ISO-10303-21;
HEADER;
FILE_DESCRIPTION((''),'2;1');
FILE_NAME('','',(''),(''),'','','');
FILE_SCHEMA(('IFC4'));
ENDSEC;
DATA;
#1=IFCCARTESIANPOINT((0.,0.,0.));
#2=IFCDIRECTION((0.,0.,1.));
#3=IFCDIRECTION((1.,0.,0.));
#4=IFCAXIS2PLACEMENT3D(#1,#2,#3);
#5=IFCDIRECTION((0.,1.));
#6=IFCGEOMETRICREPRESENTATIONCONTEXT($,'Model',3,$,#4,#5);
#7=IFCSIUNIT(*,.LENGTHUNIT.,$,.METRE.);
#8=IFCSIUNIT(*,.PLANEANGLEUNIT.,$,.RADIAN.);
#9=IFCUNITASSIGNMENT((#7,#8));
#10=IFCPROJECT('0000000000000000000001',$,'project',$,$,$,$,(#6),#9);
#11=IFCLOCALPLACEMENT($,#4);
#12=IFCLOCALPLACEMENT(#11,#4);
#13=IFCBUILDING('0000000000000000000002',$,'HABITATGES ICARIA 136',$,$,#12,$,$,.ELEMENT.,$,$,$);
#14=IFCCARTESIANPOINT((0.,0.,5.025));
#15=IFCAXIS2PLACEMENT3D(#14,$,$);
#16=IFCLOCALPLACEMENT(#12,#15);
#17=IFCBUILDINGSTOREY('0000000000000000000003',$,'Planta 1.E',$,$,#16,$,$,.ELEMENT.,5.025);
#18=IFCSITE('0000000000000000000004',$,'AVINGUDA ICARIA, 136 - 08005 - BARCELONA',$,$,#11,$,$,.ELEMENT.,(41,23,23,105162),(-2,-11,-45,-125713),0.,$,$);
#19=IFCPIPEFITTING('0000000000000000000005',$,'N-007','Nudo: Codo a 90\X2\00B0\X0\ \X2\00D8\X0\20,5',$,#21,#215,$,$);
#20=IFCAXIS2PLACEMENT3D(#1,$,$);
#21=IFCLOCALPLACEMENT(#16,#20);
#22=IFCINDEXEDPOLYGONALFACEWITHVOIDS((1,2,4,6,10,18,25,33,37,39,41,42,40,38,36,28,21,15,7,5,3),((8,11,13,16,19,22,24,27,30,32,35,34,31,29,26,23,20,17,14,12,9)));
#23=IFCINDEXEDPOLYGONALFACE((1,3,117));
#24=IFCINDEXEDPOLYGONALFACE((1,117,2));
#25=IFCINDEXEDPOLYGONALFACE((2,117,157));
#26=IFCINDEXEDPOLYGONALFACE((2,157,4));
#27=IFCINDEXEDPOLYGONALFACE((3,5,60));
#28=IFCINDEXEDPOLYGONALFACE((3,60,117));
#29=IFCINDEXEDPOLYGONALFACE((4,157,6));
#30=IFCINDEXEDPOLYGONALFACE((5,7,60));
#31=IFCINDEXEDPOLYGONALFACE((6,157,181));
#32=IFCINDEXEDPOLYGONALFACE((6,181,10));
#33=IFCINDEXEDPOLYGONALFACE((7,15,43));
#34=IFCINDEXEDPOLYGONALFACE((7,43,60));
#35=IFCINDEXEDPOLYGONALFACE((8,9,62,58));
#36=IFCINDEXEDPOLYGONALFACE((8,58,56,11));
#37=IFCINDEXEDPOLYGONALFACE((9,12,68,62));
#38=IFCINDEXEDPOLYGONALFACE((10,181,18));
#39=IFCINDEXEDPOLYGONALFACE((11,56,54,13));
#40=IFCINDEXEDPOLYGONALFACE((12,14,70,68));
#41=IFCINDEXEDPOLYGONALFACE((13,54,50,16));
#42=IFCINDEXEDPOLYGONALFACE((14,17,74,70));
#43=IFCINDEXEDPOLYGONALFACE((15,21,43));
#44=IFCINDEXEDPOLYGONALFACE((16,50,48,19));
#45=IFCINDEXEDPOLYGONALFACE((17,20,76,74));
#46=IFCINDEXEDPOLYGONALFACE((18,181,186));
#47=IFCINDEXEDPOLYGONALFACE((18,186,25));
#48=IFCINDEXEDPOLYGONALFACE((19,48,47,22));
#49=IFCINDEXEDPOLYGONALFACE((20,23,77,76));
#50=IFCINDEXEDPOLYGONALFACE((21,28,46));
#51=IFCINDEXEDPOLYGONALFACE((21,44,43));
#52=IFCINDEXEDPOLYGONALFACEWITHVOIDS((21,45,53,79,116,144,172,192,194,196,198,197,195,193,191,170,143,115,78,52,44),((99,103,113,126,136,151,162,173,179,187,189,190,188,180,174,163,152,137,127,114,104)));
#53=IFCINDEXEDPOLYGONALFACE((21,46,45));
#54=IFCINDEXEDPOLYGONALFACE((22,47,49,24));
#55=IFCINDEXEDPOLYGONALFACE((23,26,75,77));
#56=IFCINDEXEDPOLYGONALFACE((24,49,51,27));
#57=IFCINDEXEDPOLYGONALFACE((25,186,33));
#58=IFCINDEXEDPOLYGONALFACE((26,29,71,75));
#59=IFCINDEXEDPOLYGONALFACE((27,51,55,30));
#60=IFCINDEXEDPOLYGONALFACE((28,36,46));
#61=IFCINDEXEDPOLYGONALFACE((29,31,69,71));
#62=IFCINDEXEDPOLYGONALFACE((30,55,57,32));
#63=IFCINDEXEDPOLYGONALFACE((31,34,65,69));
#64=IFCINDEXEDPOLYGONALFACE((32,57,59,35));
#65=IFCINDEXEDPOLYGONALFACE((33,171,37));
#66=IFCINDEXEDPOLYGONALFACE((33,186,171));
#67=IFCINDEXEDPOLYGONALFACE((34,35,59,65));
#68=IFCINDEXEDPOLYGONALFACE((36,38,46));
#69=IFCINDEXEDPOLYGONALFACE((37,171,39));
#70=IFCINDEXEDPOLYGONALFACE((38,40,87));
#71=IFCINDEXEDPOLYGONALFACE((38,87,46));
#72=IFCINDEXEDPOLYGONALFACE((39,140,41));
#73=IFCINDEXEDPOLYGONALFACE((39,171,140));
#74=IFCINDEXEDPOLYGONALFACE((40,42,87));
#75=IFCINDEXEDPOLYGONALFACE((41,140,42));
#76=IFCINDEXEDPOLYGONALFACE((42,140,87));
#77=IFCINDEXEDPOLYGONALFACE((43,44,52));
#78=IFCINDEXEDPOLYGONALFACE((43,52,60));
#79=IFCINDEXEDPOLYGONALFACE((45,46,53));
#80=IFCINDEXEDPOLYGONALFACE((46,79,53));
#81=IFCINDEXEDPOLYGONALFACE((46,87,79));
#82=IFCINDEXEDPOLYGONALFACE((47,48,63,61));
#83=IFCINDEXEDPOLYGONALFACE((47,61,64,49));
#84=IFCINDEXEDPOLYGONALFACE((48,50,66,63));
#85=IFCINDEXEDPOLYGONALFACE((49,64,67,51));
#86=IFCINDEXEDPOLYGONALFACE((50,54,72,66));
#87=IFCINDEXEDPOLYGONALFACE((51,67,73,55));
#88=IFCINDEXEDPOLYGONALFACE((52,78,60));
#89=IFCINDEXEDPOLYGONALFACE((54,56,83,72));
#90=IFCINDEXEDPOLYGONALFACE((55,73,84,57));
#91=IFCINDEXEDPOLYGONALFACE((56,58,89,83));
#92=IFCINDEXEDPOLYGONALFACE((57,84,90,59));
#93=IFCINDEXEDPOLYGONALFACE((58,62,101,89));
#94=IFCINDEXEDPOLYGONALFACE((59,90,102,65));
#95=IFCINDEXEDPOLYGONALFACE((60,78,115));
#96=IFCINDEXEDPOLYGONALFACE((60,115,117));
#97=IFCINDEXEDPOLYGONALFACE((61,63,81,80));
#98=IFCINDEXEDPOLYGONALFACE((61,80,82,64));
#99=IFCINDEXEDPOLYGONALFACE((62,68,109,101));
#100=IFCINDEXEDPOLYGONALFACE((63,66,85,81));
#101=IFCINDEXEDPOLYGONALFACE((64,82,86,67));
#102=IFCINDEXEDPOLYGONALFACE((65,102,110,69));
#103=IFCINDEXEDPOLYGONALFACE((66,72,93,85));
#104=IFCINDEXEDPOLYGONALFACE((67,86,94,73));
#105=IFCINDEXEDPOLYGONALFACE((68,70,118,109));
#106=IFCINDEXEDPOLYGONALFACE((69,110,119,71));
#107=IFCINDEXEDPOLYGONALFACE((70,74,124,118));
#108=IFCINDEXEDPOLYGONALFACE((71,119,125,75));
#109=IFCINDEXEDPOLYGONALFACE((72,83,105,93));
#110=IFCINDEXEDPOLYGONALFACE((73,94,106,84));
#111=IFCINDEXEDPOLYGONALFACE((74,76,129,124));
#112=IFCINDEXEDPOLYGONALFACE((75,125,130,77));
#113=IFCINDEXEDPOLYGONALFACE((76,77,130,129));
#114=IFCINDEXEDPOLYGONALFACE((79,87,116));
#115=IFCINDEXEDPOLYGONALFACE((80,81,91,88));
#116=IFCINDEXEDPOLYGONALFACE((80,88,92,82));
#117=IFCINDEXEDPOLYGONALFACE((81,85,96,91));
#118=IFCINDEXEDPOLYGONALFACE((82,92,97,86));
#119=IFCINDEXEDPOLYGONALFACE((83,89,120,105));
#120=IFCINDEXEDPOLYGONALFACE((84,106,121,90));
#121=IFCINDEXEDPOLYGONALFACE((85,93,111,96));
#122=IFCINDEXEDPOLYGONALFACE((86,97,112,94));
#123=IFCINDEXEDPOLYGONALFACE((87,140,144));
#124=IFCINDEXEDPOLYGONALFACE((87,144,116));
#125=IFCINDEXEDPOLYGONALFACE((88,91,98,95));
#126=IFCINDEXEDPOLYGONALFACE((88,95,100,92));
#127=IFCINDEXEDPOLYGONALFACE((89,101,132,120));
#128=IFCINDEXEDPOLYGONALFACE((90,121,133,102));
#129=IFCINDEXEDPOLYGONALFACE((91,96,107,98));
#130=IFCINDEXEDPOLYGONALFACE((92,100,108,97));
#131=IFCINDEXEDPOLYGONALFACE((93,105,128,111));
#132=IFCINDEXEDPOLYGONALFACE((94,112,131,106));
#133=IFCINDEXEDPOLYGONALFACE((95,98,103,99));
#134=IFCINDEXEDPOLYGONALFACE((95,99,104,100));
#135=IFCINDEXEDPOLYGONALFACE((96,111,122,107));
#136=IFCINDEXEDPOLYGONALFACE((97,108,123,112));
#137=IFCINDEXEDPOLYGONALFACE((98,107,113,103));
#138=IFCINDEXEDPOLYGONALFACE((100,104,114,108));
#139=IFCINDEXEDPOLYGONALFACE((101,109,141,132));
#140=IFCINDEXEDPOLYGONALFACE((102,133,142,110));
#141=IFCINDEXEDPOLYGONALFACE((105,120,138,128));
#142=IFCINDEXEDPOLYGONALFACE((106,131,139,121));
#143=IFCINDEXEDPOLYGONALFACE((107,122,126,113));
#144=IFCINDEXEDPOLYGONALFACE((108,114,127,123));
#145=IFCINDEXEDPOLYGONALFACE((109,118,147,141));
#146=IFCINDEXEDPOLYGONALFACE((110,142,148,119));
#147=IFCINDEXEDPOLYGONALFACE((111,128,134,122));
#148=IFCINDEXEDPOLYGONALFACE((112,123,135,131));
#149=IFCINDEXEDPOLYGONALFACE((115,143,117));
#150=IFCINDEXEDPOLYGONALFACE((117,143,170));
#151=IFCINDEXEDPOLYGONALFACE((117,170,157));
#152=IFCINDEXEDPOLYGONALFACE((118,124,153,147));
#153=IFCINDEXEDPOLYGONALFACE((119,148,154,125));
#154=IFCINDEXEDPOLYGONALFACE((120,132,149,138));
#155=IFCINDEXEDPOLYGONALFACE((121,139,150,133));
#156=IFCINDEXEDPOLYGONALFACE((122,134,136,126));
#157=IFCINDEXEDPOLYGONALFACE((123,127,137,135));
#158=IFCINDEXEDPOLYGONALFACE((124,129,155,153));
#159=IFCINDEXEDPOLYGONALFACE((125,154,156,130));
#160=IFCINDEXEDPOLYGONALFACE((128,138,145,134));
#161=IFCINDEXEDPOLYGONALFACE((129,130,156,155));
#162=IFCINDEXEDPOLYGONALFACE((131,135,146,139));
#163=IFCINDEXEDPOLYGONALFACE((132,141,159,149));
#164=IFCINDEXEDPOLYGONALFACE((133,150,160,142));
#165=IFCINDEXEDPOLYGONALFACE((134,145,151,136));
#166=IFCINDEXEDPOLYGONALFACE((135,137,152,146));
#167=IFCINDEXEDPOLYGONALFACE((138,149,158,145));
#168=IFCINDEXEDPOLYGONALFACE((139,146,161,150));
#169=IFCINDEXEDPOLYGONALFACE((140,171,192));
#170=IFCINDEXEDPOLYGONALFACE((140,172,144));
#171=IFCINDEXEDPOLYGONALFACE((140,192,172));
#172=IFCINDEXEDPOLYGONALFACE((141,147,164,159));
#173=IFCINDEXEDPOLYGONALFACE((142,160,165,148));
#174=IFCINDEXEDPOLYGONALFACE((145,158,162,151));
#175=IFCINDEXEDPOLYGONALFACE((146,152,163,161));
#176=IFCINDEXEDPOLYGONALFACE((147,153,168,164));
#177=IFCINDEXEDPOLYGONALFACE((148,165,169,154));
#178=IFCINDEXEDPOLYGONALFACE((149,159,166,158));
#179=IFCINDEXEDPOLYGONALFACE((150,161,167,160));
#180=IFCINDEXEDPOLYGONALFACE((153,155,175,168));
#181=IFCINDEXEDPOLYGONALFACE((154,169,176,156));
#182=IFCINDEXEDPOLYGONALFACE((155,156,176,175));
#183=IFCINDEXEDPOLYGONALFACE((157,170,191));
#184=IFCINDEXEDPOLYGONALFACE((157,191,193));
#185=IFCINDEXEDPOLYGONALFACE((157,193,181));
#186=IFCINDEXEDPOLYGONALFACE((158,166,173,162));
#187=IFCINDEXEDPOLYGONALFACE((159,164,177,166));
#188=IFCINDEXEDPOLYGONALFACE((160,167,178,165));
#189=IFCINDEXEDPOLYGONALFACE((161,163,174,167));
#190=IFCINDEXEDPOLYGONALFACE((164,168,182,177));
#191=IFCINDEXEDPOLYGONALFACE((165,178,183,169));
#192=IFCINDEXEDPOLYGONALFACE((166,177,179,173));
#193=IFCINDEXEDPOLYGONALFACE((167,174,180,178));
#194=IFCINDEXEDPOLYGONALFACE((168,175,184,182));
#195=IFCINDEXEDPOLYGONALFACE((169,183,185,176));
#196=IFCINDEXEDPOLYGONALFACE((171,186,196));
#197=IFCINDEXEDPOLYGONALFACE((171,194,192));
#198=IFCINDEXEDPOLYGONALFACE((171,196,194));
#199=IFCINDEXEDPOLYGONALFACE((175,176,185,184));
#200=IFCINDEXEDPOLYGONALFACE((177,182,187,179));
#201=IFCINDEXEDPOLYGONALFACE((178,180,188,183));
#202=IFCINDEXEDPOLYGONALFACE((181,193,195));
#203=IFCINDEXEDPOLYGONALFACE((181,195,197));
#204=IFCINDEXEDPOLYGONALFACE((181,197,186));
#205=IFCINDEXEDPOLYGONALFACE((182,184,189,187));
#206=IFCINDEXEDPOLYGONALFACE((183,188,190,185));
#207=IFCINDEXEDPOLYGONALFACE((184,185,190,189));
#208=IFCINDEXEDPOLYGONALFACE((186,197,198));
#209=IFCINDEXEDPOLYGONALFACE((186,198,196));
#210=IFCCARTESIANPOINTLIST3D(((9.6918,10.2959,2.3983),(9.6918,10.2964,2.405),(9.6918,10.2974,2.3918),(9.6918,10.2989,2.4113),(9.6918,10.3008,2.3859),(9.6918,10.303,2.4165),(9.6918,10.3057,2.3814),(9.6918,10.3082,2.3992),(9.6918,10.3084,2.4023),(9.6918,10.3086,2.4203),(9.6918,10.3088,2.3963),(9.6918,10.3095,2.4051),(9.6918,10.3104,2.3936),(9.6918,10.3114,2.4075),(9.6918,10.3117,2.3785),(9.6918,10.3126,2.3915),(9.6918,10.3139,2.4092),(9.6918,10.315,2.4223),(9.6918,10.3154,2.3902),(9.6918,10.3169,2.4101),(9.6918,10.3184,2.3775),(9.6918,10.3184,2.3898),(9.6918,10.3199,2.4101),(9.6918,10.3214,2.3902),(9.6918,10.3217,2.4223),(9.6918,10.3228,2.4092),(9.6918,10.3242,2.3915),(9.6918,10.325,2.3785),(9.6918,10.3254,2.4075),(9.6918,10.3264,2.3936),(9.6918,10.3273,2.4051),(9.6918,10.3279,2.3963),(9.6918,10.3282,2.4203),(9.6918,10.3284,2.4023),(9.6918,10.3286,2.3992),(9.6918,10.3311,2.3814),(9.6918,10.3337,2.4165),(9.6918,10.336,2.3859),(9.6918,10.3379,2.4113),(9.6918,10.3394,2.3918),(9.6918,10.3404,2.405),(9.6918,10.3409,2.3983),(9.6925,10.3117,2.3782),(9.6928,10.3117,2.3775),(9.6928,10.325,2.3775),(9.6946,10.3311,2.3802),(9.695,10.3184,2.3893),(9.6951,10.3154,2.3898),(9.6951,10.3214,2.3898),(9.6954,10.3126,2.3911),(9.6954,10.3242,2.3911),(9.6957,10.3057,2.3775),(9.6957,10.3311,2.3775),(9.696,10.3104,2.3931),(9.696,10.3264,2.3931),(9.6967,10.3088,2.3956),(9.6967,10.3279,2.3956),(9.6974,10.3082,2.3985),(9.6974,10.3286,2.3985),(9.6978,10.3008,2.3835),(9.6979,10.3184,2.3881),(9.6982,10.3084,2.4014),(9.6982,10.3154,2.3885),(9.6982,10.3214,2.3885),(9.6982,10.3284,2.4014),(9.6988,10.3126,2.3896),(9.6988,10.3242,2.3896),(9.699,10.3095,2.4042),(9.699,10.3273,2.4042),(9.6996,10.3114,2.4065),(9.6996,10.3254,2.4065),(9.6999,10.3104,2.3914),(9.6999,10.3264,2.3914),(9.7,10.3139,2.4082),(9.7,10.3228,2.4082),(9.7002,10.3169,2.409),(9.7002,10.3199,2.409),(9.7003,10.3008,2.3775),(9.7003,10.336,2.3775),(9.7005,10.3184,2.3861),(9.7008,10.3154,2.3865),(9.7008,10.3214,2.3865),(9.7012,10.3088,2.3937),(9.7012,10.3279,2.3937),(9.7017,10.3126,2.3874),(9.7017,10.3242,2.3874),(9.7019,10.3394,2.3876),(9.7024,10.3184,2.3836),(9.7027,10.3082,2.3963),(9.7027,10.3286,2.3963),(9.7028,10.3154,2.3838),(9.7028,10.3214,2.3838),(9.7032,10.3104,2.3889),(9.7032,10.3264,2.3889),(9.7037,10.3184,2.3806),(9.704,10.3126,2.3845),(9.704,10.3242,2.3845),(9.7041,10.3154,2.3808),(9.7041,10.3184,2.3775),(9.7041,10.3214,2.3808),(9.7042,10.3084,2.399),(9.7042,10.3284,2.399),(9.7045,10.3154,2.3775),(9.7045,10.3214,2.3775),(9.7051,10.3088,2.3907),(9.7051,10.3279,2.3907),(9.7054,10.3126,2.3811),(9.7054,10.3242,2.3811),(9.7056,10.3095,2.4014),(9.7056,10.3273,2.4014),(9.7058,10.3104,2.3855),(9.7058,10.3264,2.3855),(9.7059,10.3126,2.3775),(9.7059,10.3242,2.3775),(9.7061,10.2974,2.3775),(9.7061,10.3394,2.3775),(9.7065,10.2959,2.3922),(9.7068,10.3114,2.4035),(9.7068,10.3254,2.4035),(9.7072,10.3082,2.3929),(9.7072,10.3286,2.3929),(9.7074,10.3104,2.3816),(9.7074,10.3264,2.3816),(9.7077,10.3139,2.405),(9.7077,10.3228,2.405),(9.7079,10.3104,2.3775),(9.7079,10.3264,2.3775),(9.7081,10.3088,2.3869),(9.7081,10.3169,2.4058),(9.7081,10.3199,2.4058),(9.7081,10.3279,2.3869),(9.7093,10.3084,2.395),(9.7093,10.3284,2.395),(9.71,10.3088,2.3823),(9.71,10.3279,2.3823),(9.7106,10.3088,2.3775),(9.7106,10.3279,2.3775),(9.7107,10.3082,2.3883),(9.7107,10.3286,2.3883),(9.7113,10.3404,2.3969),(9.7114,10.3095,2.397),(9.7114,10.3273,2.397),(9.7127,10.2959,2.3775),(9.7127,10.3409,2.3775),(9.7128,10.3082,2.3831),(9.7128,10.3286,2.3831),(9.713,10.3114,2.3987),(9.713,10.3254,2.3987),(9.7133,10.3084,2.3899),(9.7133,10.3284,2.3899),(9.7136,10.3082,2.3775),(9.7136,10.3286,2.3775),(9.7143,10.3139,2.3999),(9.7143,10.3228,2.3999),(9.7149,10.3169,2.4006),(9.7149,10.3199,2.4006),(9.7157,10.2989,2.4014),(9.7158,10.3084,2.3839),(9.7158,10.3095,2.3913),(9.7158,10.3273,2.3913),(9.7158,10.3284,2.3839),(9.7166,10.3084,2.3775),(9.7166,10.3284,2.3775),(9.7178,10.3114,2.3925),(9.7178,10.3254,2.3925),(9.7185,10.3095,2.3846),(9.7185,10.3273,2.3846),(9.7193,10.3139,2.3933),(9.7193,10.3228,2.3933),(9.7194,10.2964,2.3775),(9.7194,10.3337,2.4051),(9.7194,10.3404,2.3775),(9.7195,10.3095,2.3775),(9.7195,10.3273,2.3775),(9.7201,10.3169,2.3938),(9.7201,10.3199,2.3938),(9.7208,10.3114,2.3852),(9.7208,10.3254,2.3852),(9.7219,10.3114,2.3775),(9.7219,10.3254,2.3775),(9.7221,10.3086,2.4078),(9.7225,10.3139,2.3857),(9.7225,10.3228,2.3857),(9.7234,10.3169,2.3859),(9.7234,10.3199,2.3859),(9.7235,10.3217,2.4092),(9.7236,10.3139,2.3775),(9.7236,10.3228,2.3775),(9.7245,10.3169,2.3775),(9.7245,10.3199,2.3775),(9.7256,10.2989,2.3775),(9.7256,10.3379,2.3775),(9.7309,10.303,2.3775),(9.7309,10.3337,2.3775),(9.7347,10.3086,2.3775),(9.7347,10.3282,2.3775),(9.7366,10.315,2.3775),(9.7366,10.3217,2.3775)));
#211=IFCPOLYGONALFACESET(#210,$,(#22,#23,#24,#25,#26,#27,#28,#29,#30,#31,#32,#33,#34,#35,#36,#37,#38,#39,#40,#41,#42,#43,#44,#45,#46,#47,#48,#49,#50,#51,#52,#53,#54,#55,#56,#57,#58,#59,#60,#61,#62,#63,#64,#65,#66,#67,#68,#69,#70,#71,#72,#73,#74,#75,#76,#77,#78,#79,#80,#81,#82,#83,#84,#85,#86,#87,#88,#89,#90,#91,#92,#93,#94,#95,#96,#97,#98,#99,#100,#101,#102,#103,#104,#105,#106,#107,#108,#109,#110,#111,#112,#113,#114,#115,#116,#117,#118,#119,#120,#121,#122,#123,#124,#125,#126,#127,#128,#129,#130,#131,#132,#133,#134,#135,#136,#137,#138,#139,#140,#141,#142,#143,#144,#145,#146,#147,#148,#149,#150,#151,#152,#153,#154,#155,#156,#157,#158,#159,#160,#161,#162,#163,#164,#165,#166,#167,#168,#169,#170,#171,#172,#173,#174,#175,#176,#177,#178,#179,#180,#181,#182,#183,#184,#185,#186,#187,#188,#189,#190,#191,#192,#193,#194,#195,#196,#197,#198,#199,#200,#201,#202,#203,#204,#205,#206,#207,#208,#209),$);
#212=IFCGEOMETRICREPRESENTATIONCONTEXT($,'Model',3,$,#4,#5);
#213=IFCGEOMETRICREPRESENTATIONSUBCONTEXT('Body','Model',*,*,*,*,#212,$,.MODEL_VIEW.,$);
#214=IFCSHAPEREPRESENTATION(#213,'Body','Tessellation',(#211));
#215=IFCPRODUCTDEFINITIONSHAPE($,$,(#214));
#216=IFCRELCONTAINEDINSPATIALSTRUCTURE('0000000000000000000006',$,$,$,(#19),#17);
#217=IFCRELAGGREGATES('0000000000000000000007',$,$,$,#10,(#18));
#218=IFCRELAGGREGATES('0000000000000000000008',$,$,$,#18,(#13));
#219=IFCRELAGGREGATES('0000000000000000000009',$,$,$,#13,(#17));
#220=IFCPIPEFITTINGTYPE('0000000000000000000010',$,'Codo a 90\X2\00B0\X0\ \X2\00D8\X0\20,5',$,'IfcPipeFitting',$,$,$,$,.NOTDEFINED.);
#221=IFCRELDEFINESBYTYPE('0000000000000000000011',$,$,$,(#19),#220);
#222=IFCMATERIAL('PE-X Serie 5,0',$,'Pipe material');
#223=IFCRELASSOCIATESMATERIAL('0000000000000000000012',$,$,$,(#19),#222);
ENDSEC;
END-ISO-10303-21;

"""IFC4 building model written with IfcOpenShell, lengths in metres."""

from ifc_helpers import new_model, entity, si_unit, direction, frame, origin_with_axes, place, context, subcontext, project, spatial, source, transform, mapped, material, type_object, element, save


model = new_model("IFC4")

# Units and contexts
model_context_1 = context("Model", 3, world=origin_with_axes(), true_north=direction((0.0, 1.0)))
model_context_2 = context("Model", 3, world=origin_with_axes(), true_north=direction((0.0, 1.0)))
body_context_1 = subcontext(model_context_2, "Body", "Model", "MODEL_VIEW")
ifc_project = project(units=[si_unit("LENGTHUNIT", "METRE"), si_unit("PLANEANGLEUNIT", "RADIAN")], contexts=[model_context_1])

# Site, building, storey
site_placement = place(None, origin_with_axes())
site = spatial("IfcSite", under=ifc_project, at=site_placement, Name="AVINGUDA ICARIA, 136 - 08005 - BARCELONA", CompositionType="ELEMENT", RefLatitude=(41, 23, 23, 105162), RefLongitude=(-2, -11, -45, -125713), RefElevation=0.0)
building_placement = place(site_placement, origin_with_axes())
building = spatial("IfcBuilding", under=site, at=building_placement, Name="HABITATGES ICARIA 136", CompositionType="ELEMENT")
storey_placement = place(building_placement, frame((0.0, 0.0, 5.025)))
storey = spatial("IfcBuildingStorey", under=building, at=storey_placement, Name="Planta 1.E", CompositionType="ELEMENT", Elevation=5.025)

# Shared definitions
ifc_material_1 = material(Name="PE-X Serie 5,0", Category="Pipe material")
placement_1 = place(None, origin_with_axes())
placement_2 = place(placement_1, origin_with_axes())
placement_3 = place(placement_2, frame((0.0, 0.0, 5.025)))

# Pipe fitting
pipe_fitting_type_1 = type_object("IfcPipeFittingType", Name="Codo a 90° Ø20,5", ApplicableOccurrence="IfcPipeFitting", PredefinedType="NOTDEFINED")
shared_shape_1 = source(origin_with_axes(), body_context_1, "Body", "SweptSolid", [
    entity("IfcRevolvedAreaSolid", entity("IfcCircleHollowProfileDef", "AREA", None, entity("IfcAxis2Placement2D", entity("IfcCartesianPoint", [0.0, 0.0]), entity("IfcDirection", [1.0, 0.0])), 0.0226, 0.0123), entity("IfcAxis2Placement3D", entity("IfcCartesianPoint", [0.0226, 0.0, 0.0]), entity("IfcDirection", [-1.0, 0.0, 0.0]), entity("IfcDirection", [0.0, -1.0, 0.0])), entity("IfcAxis1Placement", entity("IfcCartesianPoint", [0.0226, 0.0, 0.0]), entity("IfcDirection", [0.0, 1.0, 0.0])), 1.570796),
])
pipe_fitting_1_placement = place(placement_3, origin_with_axes())
element("IfcPipeFitting", 1, at=pipe_fitting_1_placement, inside=storey, type_object=pipe_fitting_type_1, material=ifc_material_1, Name="N-007", Description="Nudo: Codo a 90° Ø20,5", context=body_context_1, shape_type="MappedRepresentation", body=[
    mapped(shared_shape_1, transform((9.7143, 10.3184, 2.4), x_axis=(-1.0, 0.0, 0.0), y_axis=(0.0, 0.0, 1.0), z_axis=(0.0, 1.0, 0.0), scale=1.0)),
])

save(model, "model.ifc")
